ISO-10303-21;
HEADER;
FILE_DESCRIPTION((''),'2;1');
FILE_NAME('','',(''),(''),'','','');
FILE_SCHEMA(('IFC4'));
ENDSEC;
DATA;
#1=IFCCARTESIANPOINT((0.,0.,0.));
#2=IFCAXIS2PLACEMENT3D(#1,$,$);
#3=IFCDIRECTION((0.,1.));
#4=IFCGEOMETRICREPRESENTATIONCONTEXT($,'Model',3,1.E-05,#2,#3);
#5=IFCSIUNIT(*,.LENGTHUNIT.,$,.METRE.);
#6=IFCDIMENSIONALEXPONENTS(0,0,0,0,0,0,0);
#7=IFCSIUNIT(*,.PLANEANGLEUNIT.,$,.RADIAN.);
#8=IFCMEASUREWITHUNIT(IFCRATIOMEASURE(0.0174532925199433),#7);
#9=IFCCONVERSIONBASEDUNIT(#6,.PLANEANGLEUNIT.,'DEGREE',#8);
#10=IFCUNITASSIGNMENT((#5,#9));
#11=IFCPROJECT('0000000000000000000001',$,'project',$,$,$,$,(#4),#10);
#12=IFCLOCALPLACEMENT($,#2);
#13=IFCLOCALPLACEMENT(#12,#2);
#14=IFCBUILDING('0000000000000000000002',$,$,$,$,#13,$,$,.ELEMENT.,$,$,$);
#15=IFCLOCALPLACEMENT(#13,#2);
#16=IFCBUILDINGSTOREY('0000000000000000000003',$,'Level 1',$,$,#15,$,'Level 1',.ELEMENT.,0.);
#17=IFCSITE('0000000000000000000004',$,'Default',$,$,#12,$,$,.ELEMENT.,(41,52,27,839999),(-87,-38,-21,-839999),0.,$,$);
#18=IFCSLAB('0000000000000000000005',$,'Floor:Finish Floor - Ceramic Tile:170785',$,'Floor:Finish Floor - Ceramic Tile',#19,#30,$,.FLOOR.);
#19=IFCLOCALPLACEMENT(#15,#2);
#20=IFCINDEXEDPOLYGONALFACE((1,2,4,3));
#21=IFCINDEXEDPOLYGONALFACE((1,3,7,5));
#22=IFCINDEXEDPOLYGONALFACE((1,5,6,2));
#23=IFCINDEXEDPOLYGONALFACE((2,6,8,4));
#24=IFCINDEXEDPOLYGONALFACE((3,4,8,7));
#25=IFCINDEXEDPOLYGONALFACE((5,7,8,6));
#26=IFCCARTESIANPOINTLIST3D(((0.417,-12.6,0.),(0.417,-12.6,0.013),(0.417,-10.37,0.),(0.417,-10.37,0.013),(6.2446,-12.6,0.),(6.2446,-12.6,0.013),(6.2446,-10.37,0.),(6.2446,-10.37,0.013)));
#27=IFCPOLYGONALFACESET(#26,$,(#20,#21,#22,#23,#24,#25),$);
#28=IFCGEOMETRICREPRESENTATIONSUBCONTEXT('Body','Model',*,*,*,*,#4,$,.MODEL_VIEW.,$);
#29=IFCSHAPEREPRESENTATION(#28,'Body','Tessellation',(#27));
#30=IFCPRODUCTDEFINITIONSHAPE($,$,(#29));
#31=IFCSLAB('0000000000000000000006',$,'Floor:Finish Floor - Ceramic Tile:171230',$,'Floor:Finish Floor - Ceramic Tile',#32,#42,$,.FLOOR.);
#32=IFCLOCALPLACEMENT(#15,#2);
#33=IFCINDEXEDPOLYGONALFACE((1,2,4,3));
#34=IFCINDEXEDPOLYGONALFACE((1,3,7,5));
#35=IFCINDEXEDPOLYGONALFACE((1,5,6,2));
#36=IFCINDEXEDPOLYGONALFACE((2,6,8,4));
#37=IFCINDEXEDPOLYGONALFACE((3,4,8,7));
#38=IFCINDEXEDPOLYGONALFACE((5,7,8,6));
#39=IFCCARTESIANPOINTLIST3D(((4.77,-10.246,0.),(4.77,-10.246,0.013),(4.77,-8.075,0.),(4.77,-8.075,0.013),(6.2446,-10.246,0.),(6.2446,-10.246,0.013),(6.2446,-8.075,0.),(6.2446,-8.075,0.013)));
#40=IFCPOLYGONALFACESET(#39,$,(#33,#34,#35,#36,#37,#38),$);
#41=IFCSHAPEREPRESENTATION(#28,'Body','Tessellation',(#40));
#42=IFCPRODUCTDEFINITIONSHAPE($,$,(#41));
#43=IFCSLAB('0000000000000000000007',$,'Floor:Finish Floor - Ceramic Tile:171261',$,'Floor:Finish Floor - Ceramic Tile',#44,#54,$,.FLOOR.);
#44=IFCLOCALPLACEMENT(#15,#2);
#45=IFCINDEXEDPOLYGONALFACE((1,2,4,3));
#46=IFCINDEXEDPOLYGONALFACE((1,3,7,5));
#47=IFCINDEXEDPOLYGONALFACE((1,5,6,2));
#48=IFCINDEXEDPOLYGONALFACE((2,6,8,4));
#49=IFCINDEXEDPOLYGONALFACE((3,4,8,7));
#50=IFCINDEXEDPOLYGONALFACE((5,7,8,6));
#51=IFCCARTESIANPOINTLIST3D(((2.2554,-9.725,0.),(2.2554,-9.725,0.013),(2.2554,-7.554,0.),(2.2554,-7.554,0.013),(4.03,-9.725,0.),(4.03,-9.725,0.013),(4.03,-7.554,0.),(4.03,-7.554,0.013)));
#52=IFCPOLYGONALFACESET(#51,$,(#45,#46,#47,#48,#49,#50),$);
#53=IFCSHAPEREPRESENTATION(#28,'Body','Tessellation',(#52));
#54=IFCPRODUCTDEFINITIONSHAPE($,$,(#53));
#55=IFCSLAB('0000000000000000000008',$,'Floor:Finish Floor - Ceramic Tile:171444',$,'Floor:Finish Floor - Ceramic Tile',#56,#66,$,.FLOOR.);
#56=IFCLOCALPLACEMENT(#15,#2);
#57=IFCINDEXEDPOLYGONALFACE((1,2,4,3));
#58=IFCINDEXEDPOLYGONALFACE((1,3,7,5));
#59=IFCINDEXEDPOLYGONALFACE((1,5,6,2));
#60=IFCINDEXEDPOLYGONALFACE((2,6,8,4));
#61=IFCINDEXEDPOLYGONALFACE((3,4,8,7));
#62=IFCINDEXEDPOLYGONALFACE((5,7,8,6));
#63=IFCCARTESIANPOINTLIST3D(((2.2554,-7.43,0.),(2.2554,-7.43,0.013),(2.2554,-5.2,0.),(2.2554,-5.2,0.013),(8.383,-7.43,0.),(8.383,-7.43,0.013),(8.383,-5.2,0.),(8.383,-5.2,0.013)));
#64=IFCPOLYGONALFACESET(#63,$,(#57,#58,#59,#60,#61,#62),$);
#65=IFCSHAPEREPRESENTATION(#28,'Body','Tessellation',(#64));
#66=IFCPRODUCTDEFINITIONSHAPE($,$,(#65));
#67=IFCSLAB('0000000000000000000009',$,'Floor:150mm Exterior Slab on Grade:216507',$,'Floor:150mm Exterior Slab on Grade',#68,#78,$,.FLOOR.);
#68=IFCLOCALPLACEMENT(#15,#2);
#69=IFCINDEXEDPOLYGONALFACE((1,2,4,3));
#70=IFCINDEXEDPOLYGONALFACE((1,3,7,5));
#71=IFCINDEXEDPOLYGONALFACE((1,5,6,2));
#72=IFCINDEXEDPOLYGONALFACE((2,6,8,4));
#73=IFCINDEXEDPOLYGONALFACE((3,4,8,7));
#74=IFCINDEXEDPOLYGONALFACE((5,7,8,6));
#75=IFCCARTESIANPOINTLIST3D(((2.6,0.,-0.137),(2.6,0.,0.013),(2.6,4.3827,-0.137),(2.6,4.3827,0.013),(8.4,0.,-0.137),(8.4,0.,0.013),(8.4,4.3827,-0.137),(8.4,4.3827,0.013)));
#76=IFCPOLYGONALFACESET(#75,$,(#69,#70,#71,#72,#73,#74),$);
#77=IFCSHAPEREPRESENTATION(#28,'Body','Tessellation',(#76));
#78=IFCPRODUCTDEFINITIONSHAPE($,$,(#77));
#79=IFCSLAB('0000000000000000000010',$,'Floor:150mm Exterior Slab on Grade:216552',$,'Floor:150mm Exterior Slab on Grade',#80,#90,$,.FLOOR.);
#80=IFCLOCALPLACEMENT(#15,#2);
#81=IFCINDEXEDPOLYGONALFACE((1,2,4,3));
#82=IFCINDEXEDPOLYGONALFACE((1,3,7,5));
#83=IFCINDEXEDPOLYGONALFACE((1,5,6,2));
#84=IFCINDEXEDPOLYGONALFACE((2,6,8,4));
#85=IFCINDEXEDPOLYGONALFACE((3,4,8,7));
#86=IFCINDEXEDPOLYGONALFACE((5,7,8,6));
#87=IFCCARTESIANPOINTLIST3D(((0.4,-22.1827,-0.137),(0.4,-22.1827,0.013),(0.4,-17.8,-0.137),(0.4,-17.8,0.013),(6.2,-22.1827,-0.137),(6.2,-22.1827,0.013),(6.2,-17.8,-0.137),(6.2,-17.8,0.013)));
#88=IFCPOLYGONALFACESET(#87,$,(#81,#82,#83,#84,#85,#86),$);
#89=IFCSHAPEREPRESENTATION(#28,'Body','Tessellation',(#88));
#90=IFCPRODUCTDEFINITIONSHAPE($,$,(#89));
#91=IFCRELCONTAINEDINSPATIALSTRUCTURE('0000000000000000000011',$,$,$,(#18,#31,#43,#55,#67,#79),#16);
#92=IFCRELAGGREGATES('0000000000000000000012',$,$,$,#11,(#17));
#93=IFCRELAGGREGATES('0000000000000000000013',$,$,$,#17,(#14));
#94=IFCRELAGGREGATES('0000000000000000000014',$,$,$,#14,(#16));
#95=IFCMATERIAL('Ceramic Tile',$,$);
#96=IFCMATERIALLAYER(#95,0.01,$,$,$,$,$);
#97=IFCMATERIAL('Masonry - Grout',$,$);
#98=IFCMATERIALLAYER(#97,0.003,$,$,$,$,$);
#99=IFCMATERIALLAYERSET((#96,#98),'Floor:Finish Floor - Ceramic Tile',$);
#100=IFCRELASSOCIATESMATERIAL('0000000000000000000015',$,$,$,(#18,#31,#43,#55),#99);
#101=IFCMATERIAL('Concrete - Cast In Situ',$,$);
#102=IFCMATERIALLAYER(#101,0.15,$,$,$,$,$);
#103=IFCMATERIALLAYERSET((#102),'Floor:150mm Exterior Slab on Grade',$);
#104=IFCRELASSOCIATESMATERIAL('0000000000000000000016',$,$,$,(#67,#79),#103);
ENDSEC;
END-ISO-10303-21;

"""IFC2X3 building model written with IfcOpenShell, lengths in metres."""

from ifc_helpers import new_model, entity, si_unit, converted_unit, direction, frame, frame_2d, origin, origin_2d_with_axis, place, context, subcontext, project, spatial, rectangle, extrude, material, layer, layer_set, layer_usage, element, save


model = new_model("IFC2X3")

# Units and contexts
model_context = context("Model", 3, precision=1e-05, world=origin(), true_north=direction((0.0, 1.0)))
body_context = subcontext(model_context, "Body", "Model", "MODEL_VIEW")
ifc_project = project(units=[si_unit("LENGTHUNIT", "METRE"), converted_unit("PLANEANGLEUNIT", "DEGREE", entity("IfcRatioMeasure", 0.0174532925199433), si_unit("PLANEANGLEUNIT", "RADIAN"), dimensions=[0, 0, 0, 0, 0, 0, 0])], contexts=[model_context])

# Site, building, storey
site_placement = place(None, origin())
site = spatial("IfcSite", under=ifc_project, at=site_placement, Name="Default", CompositionType="ELEMENT", RefLatitude=(41, 52, 27, 839999), RefLongitude=(-87, -38, -21, -839999), RefElevation=0.0)
building_placement = place(site_placement, origin())
building = spatial("IfcBuilding", under=site, at=building_placement, CompositionType="ELEMENT")
storey_placement = place(building_placement, origin())
storey = spatial("IfcBuildingStorey", under=building, at=storey_placement, Name="Level 1", LongName="Level 1", CompositionType="ELEMENT", Elevation=0.0)

# Slabs
ifc_material_1 = material(Name="Ceramic Tile")
ifc_layer_1 = layer(ifc_material_1, 0.01)
ifc_material_2 = material(Name="Masonry - Grout")
ifc_layer_2 = layer(ifc_material_2, 0.003)
ifc_layer_set_1 = layer_set([ifc_layer_1, ifc_layer_2], Name="Floor:Finish Floor - Ceramic Tile")
ifc_layer_usage_1 = layer_usage(ifc_layer_set_1, "AXIS3", "POSITIVE", 0.0)
slab_1_placement = place(storey_placement, origin())
element("IfcSlab", 1, at=slab_1_placement, inside=storey, material=ifc_layer_usage_1, Name="Floor:Finish Floor - Ceramic Tile:170785", ObjectType="Floor:Finish Floor - Ceramic Tile", PredefinedType="FLOOR", context=body_context, shape_type="SweptSolid", body=[
    extrude(rectangle(XDim=2.23, YDim=5.8276, at=frame_2d((0.0, 0.0), x_axis=(1.0, 0.0))), frame((3.3308, -11.485, 0.013), z_axis=(0.0, 0.0, -1.0), x_axis=(0.0, 1.0, 0.0)), (0.0, 0.0, 1.0), 0.013),
])
ifc_layer_usage_2 = layer_usage(ifc_layer_set_1, "AXIS3", "POSITIVE", 0.0)
slab_2_placement = place(storey_placement, origin())
element("IfcSlab", 2, at=slab_2_placement, inside=storey, material=ifc_layer_usage_2, Name="Floor:Finish Floor - Ceramic Tile:171230", ObjectType="Floor:Finish Floor - Ceramic Tile", PredefinedType="FLOOR", context=body_context, shape_type="SweptSolid", body=[
    extrude(rectangle(XDim=2.171, YDim=1.4746, at=origin_2d_with_axis()), frame((5.5073, -9.1605, 0.013), z_axis=(0.0, 0.0, -1.0), x_axis=(0.0, 1.0, 0.0)), (0.0, 0.0, 1.0), 0.013),
])
ifc_layer_usage_3 = layer_usage(ifc_layer_set_1, "AXIS3", "POSITIVE", 0.0)
slab_3_placement = place(storey_placement, origin())
element("IfcSlab", 3, at=slab_3_placement, inside=storey, material=ifc_layer_usage_3, Name="Floor:Finish Floor - Ceramic Tile:171261", ObjectType="Floor:Finish Floor - Ceramic Tile", PredefinedType="FLOOR", context=body_context, shape_type="SweptSolid", body=[
    extrude(rectangle(XDim=2.171, YDim=1.7746, at=frame_2d((0.0, 0.0), x_axis=(1.0, 0.0))), frame((3.1427, -8.6395, 0.013), z_axis=(0.0, 0.0, -1.0), x_axis=(0.0, 1.0, 0.0)), (0.0, 0.0, 1.0), 0.013),
])
ifc_layer_usage_4 = layer_usage(ifc_layer_set_1, "AXIS3", "POSITIVE", 0.0)
slab_4_placement = place(storey_placement, origin())
element("IfcSlab", 4, at=slab_4_placement, inside=storey, material=ifc_layer_usage_4, Name="Floor:Finish Floor - Ceramic Tile:171444", ObjectType="Floor:Finish Floor - Ceramic Tile", PredefinedType="FLOOR", context=body_context, shape_type="SweptSolid", body=[
    extrude(rectangle(XDim=2.23, YDim=6.1276, at=frame_2d((0.0, 0.0), x_axis=(1.0, 0.0))), frame((5.3192, -6.315, 0.013), z_axis=(0.0, 0.0, -1.0), x_axis=(0.0, 1.0, 0.0)), (0.0, 0.0, 1.0), 0.013),
])
ifc_material_3 = material(Name="Concrete - Cast In Situ")
ifc_layer_3 = layer(ifc_material_3, 0.15)
ifc_layer_set_2 = layer_set([ifc_layer_3], Name="Floor:150mm Exterior Slab on Grade")
ifc_layer_usage_5 = layer_usage(ifc_layer_set_2, "AXIS3", "POSITIVE", 0.0)
slab_5_placement = place(storey_placement, origin())
element("IfcSlab", 5, at=slab_5_placement, inside=storey, material=ifc_layer_usage_5, Name="Floor:150mm Exterior Slab on Grade:216507", ObjectType="Floor:150mm Exterior Slab on Grade", PredefinedType="FLOOR", context=body_context, shape_type="SweptSolid", body=[
    extrude(rectangle(XDim=4.3827, YDim=5.8, at=frame_2d((0.0, 0.0), x_axis=(1.0, 0.0))), frame((5.5, 2.1914, 0.013), z_axis=(0.0, 0.0, -1.0), x_axis=(0.0, 1.0, 0.0)), (0.0, 0.0, 1.0), 0.15),
])
ifc_layer_usage_6 = layer_usage(ifc_layer_set_2, "AXIS3", "POSITIVE", 0.0)
slab_6_placement = place(storey_placement, origin())
element("IfcSlab", 6, at=slab_6_placement, inside=storey, material=ifc_layer_usage_6, Name="Floor:150mm Exterior Slab on Grade:216552", ObjectType="Floor:150mm Exterior Slab on Grade", PredefinedType="FLOOR", context=body_context, shape_type="SweptSolid", body=[
    extrude(rectangle(XDim=4.3827, YDim=5.8, at=frame_2d((0.0, 0.0), x_axis=(1.0, 0.0))), frame((3.3, -19.9914, 0.013), z_axis=(0.0, 0.0, -1.0), x_axis=(0.0, 1.0, 0.0)), (0.0, 0.0, 1.0), 0.15),
])

save(model, "model.ifc")
